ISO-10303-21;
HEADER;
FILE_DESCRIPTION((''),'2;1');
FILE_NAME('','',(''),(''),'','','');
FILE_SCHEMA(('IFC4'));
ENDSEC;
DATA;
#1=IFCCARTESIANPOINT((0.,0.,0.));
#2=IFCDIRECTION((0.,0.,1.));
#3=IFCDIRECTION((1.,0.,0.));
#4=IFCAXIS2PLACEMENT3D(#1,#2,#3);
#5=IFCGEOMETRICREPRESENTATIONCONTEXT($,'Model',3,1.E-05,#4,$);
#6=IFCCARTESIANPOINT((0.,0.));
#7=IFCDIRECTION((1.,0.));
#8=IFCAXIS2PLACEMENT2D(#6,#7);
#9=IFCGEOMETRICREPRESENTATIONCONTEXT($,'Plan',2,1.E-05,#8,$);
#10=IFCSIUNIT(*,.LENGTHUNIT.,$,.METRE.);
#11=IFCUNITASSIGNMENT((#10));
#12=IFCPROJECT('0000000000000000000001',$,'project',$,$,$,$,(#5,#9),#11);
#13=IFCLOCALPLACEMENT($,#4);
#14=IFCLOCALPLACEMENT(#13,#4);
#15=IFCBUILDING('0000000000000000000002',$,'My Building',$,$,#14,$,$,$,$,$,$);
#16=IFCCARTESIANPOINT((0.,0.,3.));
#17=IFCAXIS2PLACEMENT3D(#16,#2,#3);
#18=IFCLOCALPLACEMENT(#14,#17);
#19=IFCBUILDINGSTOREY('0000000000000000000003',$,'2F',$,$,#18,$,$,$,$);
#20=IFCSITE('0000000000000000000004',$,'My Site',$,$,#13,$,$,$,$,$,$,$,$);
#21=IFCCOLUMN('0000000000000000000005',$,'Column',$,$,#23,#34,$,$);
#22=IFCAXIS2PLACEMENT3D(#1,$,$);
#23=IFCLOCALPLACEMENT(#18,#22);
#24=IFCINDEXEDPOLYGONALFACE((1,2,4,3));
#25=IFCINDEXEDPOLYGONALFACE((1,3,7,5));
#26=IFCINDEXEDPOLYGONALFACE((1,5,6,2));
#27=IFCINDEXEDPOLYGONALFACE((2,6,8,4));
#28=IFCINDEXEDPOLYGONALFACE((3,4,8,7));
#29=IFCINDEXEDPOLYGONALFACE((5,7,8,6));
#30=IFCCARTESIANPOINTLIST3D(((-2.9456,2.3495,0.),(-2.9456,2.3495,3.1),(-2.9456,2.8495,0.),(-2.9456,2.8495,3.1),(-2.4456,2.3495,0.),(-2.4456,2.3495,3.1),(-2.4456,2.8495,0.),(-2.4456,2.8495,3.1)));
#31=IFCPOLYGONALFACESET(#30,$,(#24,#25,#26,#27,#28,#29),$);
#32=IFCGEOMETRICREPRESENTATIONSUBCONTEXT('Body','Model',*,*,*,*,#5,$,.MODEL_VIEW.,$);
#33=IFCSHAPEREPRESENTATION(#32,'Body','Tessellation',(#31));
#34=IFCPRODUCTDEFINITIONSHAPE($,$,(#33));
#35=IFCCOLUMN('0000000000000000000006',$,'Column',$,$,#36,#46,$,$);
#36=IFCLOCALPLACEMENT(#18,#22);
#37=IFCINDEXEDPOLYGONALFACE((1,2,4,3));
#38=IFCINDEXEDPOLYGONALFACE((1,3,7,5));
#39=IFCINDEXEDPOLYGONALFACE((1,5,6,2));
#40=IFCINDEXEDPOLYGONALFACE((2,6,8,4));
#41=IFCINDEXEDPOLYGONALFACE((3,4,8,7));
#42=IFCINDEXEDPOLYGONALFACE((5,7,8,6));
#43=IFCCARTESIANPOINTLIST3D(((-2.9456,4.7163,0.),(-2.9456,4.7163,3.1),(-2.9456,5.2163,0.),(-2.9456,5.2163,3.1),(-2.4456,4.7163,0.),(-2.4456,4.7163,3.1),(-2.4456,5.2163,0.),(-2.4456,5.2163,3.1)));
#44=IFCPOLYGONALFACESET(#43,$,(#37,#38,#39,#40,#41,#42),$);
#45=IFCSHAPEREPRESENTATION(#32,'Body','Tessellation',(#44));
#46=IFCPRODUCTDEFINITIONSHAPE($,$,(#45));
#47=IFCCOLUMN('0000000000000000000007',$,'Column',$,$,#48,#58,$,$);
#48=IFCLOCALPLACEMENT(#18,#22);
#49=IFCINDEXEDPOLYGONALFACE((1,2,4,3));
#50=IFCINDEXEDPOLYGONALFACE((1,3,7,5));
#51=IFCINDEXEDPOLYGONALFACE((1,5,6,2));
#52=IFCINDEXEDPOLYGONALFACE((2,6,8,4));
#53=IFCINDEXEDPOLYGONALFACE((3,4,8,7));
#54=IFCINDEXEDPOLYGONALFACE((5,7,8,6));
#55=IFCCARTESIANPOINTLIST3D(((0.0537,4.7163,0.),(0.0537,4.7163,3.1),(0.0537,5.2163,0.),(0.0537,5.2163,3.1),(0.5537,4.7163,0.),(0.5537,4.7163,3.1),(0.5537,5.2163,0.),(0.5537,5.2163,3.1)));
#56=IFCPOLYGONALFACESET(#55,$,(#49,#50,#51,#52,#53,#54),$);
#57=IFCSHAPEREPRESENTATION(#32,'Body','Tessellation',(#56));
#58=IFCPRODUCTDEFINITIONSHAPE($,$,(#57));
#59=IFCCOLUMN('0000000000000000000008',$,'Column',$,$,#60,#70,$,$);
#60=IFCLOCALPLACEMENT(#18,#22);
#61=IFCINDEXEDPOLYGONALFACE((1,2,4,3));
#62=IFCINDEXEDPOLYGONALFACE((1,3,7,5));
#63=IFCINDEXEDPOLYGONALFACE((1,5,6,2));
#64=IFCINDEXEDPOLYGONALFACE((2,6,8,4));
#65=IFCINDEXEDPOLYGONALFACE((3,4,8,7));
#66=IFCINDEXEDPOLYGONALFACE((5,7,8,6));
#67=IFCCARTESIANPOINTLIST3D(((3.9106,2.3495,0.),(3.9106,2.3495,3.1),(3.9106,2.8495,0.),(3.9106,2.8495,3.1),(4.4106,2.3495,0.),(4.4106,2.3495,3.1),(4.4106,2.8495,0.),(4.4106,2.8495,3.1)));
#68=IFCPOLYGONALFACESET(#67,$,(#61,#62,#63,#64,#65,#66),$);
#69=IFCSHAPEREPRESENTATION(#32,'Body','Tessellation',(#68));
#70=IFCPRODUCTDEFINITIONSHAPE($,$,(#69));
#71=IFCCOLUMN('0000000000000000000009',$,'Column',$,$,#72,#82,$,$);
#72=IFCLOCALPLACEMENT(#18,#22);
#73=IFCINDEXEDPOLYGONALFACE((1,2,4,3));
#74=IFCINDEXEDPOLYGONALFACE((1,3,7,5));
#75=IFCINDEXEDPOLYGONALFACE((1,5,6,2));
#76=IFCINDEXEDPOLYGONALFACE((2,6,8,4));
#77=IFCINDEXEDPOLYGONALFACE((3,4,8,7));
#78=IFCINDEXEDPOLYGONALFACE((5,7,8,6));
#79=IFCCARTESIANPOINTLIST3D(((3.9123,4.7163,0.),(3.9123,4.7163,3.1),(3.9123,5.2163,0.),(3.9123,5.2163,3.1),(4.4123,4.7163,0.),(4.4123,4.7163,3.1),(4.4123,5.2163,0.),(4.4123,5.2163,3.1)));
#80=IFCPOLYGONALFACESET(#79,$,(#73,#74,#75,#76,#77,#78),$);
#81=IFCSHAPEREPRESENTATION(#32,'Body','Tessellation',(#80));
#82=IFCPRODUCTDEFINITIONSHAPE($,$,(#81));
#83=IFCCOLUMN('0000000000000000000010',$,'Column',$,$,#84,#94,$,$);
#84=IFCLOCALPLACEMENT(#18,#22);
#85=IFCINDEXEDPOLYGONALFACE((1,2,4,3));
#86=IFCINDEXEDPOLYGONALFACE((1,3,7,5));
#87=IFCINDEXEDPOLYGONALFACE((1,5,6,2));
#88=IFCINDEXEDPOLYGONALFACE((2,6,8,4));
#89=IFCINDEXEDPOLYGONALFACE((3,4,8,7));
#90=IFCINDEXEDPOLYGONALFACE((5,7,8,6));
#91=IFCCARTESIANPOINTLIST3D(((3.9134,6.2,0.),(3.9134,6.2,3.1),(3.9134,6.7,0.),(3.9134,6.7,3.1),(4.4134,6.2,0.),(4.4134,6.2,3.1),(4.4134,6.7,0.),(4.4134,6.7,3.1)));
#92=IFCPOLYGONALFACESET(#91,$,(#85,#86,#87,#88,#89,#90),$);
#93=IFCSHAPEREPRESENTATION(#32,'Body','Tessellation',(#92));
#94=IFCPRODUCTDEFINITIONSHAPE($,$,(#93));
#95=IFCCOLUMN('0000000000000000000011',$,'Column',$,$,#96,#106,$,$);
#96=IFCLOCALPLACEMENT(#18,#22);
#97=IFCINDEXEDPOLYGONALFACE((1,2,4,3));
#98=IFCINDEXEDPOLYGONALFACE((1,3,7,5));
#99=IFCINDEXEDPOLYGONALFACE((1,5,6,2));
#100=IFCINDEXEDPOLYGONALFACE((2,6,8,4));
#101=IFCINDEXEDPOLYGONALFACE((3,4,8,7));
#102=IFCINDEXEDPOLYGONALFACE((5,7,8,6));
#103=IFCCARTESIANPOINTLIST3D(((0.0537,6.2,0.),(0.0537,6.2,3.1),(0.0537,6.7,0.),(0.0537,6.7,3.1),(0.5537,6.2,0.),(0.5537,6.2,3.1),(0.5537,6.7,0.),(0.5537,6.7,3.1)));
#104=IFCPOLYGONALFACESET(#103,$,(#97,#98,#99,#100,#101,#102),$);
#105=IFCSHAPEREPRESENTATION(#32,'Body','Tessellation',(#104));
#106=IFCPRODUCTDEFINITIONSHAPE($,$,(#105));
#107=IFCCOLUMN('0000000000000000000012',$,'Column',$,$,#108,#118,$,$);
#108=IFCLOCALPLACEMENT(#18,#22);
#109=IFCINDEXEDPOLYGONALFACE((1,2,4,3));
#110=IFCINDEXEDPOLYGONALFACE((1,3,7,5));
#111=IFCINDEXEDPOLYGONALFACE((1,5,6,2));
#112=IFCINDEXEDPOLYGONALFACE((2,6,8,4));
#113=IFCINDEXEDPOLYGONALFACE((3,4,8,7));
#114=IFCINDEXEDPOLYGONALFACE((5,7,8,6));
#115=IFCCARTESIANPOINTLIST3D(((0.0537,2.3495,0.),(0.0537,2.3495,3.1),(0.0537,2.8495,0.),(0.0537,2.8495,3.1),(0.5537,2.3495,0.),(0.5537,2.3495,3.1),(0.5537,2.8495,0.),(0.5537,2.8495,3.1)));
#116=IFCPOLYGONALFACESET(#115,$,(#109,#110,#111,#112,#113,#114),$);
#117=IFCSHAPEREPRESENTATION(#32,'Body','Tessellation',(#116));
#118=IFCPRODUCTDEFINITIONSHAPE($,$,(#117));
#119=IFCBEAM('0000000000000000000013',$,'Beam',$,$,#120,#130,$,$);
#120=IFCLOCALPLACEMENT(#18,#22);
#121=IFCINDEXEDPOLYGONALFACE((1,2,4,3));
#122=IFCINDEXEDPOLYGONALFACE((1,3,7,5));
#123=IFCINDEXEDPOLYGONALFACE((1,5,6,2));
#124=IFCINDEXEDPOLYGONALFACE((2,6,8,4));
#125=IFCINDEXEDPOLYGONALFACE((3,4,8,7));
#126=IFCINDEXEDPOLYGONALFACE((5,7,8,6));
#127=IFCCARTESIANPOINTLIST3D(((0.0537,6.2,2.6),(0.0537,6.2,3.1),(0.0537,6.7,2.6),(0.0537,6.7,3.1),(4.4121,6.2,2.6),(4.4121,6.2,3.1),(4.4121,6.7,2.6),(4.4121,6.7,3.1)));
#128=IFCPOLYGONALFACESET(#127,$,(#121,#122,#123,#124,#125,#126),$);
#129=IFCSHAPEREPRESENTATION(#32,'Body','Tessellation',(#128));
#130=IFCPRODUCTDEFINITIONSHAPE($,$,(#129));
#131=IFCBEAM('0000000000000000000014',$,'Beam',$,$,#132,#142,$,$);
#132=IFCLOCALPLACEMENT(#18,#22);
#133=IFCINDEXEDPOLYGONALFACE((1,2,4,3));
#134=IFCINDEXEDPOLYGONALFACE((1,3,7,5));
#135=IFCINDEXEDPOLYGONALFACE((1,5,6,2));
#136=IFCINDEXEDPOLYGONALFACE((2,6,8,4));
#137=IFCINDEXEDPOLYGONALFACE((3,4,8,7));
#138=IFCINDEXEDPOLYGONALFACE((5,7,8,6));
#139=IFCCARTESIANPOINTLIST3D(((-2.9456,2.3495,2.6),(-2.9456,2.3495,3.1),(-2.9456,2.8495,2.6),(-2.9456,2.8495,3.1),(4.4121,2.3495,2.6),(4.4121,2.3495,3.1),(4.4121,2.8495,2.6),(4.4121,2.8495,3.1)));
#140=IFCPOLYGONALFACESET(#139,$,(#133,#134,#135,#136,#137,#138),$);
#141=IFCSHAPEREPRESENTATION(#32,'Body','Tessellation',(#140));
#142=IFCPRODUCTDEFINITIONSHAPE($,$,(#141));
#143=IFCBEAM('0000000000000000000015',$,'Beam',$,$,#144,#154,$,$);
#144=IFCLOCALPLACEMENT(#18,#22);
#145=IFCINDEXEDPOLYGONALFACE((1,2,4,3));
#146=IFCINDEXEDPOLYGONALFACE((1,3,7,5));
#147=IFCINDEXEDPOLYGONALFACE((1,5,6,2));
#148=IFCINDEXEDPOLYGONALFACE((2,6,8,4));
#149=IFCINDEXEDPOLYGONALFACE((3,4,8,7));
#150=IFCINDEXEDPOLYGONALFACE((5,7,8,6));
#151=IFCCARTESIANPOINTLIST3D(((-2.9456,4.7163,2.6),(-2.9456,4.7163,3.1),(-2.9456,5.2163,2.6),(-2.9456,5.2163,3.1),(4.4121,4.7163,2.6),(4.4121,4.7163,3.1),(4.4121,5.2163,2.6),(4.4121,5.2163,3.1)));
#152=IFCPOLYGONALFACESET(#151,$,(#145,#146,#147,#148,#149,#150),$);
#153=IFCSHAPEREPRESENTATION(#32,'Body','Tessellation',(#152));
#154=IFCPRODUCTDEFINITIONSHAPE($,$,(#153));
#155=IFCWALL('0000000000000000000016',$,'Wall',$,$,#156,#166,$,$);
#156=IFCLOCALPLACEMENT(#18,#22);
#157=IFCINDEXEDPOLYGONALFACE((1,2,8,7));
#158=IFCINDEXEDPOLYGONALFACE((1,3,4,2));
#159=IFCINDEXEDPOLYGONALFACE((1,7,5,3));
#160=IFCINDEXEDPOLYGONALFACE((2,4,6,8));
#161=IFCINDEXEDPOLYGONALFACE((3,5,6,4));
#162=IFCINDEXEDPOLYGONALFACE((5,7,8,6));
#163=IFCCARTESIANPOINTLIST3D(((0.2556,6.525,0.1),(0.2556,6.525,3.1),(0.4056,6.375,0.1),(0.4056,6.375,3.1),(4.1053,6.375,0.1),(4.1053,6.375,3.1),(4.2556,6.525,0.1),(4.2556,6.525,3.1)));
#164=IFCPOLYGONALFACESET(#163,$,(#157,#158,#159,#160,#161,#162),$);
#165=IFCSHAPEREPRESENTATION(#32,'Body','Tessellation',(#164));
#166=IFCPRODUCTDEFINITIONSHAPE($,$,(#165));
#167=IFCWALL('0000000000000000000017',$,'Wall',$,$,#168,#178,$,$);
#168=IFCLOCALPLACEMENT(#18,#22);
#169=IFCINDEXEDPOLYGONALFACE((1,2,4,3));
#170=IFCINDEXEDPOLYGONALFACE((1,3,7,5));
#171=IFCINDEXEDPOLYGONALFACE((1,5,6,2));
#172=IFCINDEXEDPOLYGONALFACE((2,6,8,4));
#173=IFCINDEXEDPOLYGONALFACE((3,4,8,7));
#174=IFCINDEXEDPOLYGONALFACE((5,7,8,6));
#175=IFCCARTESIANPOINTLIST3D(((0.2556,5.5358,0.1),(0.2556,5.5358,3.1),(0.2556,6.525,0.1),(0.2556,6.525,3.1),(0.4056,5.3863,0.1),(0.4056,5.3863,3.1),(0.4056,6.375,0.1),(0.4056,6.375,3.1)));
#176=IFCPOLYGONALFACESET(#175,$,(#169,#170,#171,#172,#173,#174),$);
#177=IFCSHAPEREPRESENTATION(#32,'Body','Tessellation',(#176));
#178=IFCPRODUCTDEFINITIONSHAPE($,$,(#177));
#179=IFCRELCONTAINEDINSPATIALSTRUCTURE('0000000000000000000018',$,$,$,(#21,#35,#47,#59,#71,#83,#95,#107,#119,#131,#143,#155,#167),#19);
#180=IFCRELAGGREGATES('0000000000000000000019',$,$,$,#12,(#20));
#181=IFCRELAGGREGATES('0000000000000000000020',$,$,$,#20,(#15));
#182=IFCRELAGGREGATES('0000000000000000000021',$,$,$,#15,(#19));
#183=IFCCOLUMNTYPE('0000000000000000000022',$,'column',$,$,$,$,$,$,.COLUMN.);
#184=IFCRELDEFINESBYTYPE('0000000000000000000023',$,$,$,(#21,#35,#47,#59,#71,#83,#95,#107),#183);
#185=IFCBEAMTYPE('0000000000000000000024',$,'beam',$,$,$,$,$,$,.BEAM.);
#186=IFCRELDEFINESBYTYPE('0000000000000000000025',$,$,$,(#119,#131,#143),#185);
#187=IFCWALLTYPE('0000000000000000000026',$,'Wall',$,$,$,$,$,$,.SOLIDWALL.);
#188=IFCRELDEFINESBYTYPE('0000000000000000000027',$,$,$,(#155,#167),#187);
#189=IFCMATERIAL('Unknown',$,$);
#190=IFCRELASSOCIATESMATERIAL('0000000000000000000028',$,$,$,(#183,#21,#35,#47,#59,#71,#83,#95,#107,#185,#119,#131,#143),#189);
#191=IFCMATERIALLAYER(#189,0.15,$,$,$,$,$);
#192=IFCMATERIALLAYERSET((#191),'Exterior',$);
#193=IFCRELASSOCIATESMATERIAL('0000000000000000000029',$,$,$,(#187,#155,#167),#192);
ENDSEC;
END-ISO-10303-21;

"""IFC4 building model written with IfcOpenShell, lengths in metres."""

from ifc_helpers import new_model, si_unit, frame, origin_with_axes, origin_2d_with_axis, place, context, subcontext, project, spatial, line, indexed_curve, rectangle, outline, extrude, material, layer, layer_set, layer_usage, material_profile, profile_set, profile_usage, type_object, element, save


model = new_model("IFC4")

# Units and contexts
model_context = context("Model", 3, precision=1e-05, world=origin_with_axes())
plan_context = context("Plan", 2, precision=1e-05, world=origin_2d_with_axis())
body_context_1 = subcontext(model_context, "Body", "Model", "MODEL_VIEW")
ifc_project = project(units=[si_unit("LENGTHUNIT", "METRE")], contexts=[model_context, plan_context])

# Site, building, storey
site_placement = place(None, origin_with_axes())
site = spatial("IfcSite", under=ifc_project, at=site_placement, Name="My Site")
building_placement = place(site_placement, origin_with_axes())
building = spatial("IfcBuilding", under=site, at=building_placement, Name="My Building")
storey_placement = place(building_placement, frame((0.0, 0.0, 3.0), z_axis=(0.0, 0.0, 1.0), x_axis=(1.0, 0.0, 0.0)))
storey = spatial("IfcBuildingStorey", under=building, at=storey_placement, Name="2F")

# Columns
ifc_material = material(Name="Unknown")
ifc_material_profile_1 = material_profile(ifc_material, rectangle(XDim=0.5, YDim=0.5))
ifc_profile_set_1 = profile_set([ifc_material_profile_1])
ifc_profile_usage_1 = profile_usage(ifc_profile_set_1, cardinal=5)
column_type = type_object("IfcColumnType", Name="column", PredefinedType="COLUMN", material=ifc_profile_set_1)
column_1_placement = place(storey_placement, frame((-2.6956, 2.5995, 0.0), z_axis=(0.0, 0.0, 1.0), x_axis=(1.0, 0.0, 0.0)))
element("IfcColumn", 1, at=column_1_placement, inside=storey, type_object=column_type, material=ifc_profile_usage_1, Name="Column", context=body_context_1, shape_type="SweptSolid", body=[
    extrude(rectangle(XDim=0.5, YDim=0.5), origin_with_axes(), (0.0, 0.0, 1.0), 3.1),
])
ifc_profile_usage_2 = profile_usage(ifc_profile_set_1, cardinal=5)
column_2_placement = place(storey_placement, frame((-2.6956, 4.9663, 0.0), z_axis=(0.0, 0.0, 1.0), x_axis=(1.0, 0.0, 0.0)))
element("IfcColumn", 2, at=column_2_placement, inside=storey, type_object=column_type, material=ifc_profile_usage_2, Name="Column", context=body_context_1, shape_type="SweptSolid", body=[
    extrude(rectangle(XDim=0.5, YDim=0.5), origin_with_axes(), (0.0, 0.0, 1.0), 3.1),
])
ifc_profile_usage_3 = profile_usage(ifc_profile_set_1, cardinal=5)
column_3_placement = place(storey_placement, frame((0.3037, 4.9663, 0.0), z_axis=(0.0, 0.0, 1.0), x_axis=(1.0, 0.0, 0.0)))
element("IfcColumn", 3, at=column_3_placement, inside=storey, type_object=column_type, material=ifc_profile_usage_3, Name="Column", context=body_context_1, shape_type="SweptSolid", body=[
    extrude(rectangle(XDim=0.5, YDim=0.5), origin_with_axes(), (0.0, 0.0, 1.0), 3.1),
])
ifc_profile_usage_4 = profile_usage(ifc_profile_set_1, cardinal=5)
column_4_placement = place(storey_placement, frame((4.1606, 2.5995, 0.0), z_axis=(0.0, 0.0, 1.0), x_axis=(1.0, 0.0, 0.0)))
element("IfcColumn", 4, at=column_4_placement, inside=storey, type_object=column_type, material=ifc_profile_usage_4, Name="Column", context=body_context_1, shape_type="SweptSolid", body=[
    extrude(rectangle(XDim=0.5, YDim=0.5), origin_with_axes(), (0.0, 0.0, 1.0), 3.1),
])
ifc_profile_usage_5 = profile_usage(ifc_profile_set_1, cardinal=5)
column_5_placement = place(storey_placement, frame((4.1623, 4.9663, 0.0), z_axis=(0.0, 0.0, 1.0), x_axis=(1.0, 0.0, 0.0)))
element("IfcColumn", 5, at=column_5_placement, inside=storey, type_object=column_type, material=ifc_profile_usage_5, Name="Column", context=body_context_1, shape_type="SweptSolid", body=[
    extrude(rectangle(XDim=0.5, YDim=0.5), origin_with_axes(), (0.0, 0.0, 1.0), 3.1),
])
ifc_profile_usage_6 = profile_usage(ifc_profile_set_1, cardinal=5)
column_6_placement = place(storey_placement, frame((4.1634, 6.45, 0.0), z_axis=(0.0, 0.0, 1.0), x_axis=(1.0, 0.0, 0.0)))
element("IfcColumn", 6, at=column_6_placement, inside=storey, type_object=column_type, material=ifc_profile_usage_6, Name="Column", context=body_context_1, shape_type="SweptSolid", body=[
    extrude(rectangle(XDim=0.5, YDim=0.5), origin_with_axes(), (0.0, 0.0, 1.0), 3.1),
])
ifc_profile_usage_7 = profile_usage(ifc_profile_set_1, cardinal=5)
column_7_placement = place(storey_placement, frame((0.3037, 6.45, 0.0), z_axis=(0.0, 0.0, 1.0), x_axis=(1.0, 0.0, 0.0)))
element("IfcColumn", 7, at=column_7_placement, inside=storey, type_object=column_type, material=ifc_profile_usage_7, Name="Column", context=body_context_1, shape_type="SweptSolid", body=[
    extrude(rectangle(XDim=0.5, YDim=0.5), origin_with_axes(), (0.0, 0.0, 1.0), 3.1),
])
ifc_profile_usage_8 = profile_usage(ifc_profile_set_1, cardinal=5)
column_8_placement = place(storey_placement, frame((0.3037, 2.5995, 0.0), z_axis=(0.0, 0.0, 1.0), x_axis=(1.0, 0.0, 0.0)))
element("IfcColumn", 8, at=column_8_placement, inside=storey, type_object=column_type, material=ifc_profile_usage_8, Name="Column", context=body_context_1, shape_type="SweptSolid", body=[
    extrude(rectangle(XDim=0.5, YDim=0.5), origin_with_axes(), (0.0, 0.0, 1.0), 3.1),
])

# Beams
ifc_material_profile_2 = material_profile(ifc_material, rectangle(XDim=0.5, YDim=0.5))
ifc_profile_set_2 = profile_set([ifc_material_profile_2])
ifc_profile_usage_9 = profile_usage(ifc_profile_set_2, cardinal=9)
beam_type = type_object("IfcBeamType", Name="beam", PredefinedType="BEAM", material=ifc_profile_set_2)
beam_1_placement = place(storey_placement, frame((4.4121, 6.7, 3.1), z_axis=(-1.0, 0.0, 0.0), x_axis=(0.0, -1.0, 0.0)))
element("IfcBeam", 9, at=beam_1_placement, inside=storey, type_object=beam_type, material=ifc_profile_usage_9, Name="Beam", context=body_context_1, shape_type="SweptSolid", body=[
    extrude(rectangle(XDim=0.5, YDim=0.5), frame((0.25, -0.25, 0.0), z_axis=(0.0, 0.0, 1.0), x_axis=(1.0, 0.0, 0.0)), (0.0, 0.0, 1.0), 4.3584),
])
ifc_profile_usage_10 = profile_usage(ifc_profile_set_2, cardinal=9)
beam_2_placement = place(storey_placement, frame((-2.9456, 2.3495, 3.1), z_axis=(1.0, 0.0, 0.0), x_axis=(0.0, 1.0, 0.0)))
element("IfcBeam", 10, at=beam_2_placement, inside=storey, type_object=beam_type, material=ifc_profile_usage_10, Name="Beam", context=body_context_1, shape_type="SweptSolid", body=[
    extrude(rectangle(XDim=0.5, YDim=0.5), frame((0.25, -0.25, 0.0), z_axis=(0.0, 0.0, 1.0), x_axis=(1.0, 0.0, 0.0)), (0.0, 0.0, 1.0), 7.3577),
])
ifc_profile_usage_11 = profile_usage(ifc_profile_set_2, cardinal=9)
beam_3_placement = place(storey_placement, frame((-2.9456, 4.7163, 3.1), z_axis=(1.0, 0.0, 0.0), x_axis=(0.0, 1.0, 0.0)))
element("IfcBeam", 11, at=beam_3_placement, inside=storey, type_object=beam_type, material=ifc_profile_usage_11, Name="Beam", context=body_context_1, shape_type="SweptSolid", body=[
    extrude(rectangle(XDim=0.5, YDim=0.5), frame((0.25, -0.25, 0.0), z_axis=(0.0, 0.0, 1.0), x_axis=(1.0, 0.0, 0.0)), (0.0, 0.0, 1.0), 7.3577),
])

# Walls
ifc_layer_1 = layer(ifc_material, 0.15)
ifc_layer_set_1 = layer_set([ifc_layer_1], Name="Exterior")
ifc_layer_usage_1 = layer_usage(ifc_layer_set_1, "AXIS2", "POSITIVE", 0.0)
wall_type_1 = type_object("IfcWallType", Name="Wall", PredefinedType="SOLIDWALL", material=ifc_layer_set_1)
wall_1_placement = place(storey_placement, frame((4.2556, 6.525, 0.1), z_axis=(0.0, 0.0, 1.0), x_axis=(-1.0, 0.0, 0.0)))
element("IfcWall", 12, at=wall_1_placement, inside=storey, type_object=wall_type_1, material=ifc_layer_usage_1, Name="Wall", context=body_context_1, shape_type="SweptSolid", body=[
    extrude(outline(indexed_curve([(0.0, 0.0), (0.1503, 0.15), (3.85, 0.15), (4.0, 0.0)], segments=[line(1, 2, 3, 4, 1)])), origin_with_axes(), (0.0, 0.0, 1.0), 3.0),
])
ifc_layer_usage_2 = layer_usage(ifc_layer_set_1, "AXIS2", "POSITIVE", 0.0)
wall_2_placement = place(storey_placement, frame((0.2556, 6.525, 0.1), z_axis=(0.0, 0.0, 1.0), x_axis=(0.0, -1.0, 0.0)))
element("IfcWall", 13, at=wall_2_placement, inside=storey, type_object=wall_type_1, material=ifc_layer_usage_2, Name="Wall", context=body_context_1, shape_type="SweptSolid", body=[
    extrude(outline(indexed_curve([(0.0, 0.0), (0.15, 0.15), (1.1387, 0.15), (0.9892, 0.0)], segments=[line(1, 2, 3, 4, 1)])), origin_with_axes(), (0.0, 0.0, 1.0), 3.0),
])

save(model, "model.ifc")
